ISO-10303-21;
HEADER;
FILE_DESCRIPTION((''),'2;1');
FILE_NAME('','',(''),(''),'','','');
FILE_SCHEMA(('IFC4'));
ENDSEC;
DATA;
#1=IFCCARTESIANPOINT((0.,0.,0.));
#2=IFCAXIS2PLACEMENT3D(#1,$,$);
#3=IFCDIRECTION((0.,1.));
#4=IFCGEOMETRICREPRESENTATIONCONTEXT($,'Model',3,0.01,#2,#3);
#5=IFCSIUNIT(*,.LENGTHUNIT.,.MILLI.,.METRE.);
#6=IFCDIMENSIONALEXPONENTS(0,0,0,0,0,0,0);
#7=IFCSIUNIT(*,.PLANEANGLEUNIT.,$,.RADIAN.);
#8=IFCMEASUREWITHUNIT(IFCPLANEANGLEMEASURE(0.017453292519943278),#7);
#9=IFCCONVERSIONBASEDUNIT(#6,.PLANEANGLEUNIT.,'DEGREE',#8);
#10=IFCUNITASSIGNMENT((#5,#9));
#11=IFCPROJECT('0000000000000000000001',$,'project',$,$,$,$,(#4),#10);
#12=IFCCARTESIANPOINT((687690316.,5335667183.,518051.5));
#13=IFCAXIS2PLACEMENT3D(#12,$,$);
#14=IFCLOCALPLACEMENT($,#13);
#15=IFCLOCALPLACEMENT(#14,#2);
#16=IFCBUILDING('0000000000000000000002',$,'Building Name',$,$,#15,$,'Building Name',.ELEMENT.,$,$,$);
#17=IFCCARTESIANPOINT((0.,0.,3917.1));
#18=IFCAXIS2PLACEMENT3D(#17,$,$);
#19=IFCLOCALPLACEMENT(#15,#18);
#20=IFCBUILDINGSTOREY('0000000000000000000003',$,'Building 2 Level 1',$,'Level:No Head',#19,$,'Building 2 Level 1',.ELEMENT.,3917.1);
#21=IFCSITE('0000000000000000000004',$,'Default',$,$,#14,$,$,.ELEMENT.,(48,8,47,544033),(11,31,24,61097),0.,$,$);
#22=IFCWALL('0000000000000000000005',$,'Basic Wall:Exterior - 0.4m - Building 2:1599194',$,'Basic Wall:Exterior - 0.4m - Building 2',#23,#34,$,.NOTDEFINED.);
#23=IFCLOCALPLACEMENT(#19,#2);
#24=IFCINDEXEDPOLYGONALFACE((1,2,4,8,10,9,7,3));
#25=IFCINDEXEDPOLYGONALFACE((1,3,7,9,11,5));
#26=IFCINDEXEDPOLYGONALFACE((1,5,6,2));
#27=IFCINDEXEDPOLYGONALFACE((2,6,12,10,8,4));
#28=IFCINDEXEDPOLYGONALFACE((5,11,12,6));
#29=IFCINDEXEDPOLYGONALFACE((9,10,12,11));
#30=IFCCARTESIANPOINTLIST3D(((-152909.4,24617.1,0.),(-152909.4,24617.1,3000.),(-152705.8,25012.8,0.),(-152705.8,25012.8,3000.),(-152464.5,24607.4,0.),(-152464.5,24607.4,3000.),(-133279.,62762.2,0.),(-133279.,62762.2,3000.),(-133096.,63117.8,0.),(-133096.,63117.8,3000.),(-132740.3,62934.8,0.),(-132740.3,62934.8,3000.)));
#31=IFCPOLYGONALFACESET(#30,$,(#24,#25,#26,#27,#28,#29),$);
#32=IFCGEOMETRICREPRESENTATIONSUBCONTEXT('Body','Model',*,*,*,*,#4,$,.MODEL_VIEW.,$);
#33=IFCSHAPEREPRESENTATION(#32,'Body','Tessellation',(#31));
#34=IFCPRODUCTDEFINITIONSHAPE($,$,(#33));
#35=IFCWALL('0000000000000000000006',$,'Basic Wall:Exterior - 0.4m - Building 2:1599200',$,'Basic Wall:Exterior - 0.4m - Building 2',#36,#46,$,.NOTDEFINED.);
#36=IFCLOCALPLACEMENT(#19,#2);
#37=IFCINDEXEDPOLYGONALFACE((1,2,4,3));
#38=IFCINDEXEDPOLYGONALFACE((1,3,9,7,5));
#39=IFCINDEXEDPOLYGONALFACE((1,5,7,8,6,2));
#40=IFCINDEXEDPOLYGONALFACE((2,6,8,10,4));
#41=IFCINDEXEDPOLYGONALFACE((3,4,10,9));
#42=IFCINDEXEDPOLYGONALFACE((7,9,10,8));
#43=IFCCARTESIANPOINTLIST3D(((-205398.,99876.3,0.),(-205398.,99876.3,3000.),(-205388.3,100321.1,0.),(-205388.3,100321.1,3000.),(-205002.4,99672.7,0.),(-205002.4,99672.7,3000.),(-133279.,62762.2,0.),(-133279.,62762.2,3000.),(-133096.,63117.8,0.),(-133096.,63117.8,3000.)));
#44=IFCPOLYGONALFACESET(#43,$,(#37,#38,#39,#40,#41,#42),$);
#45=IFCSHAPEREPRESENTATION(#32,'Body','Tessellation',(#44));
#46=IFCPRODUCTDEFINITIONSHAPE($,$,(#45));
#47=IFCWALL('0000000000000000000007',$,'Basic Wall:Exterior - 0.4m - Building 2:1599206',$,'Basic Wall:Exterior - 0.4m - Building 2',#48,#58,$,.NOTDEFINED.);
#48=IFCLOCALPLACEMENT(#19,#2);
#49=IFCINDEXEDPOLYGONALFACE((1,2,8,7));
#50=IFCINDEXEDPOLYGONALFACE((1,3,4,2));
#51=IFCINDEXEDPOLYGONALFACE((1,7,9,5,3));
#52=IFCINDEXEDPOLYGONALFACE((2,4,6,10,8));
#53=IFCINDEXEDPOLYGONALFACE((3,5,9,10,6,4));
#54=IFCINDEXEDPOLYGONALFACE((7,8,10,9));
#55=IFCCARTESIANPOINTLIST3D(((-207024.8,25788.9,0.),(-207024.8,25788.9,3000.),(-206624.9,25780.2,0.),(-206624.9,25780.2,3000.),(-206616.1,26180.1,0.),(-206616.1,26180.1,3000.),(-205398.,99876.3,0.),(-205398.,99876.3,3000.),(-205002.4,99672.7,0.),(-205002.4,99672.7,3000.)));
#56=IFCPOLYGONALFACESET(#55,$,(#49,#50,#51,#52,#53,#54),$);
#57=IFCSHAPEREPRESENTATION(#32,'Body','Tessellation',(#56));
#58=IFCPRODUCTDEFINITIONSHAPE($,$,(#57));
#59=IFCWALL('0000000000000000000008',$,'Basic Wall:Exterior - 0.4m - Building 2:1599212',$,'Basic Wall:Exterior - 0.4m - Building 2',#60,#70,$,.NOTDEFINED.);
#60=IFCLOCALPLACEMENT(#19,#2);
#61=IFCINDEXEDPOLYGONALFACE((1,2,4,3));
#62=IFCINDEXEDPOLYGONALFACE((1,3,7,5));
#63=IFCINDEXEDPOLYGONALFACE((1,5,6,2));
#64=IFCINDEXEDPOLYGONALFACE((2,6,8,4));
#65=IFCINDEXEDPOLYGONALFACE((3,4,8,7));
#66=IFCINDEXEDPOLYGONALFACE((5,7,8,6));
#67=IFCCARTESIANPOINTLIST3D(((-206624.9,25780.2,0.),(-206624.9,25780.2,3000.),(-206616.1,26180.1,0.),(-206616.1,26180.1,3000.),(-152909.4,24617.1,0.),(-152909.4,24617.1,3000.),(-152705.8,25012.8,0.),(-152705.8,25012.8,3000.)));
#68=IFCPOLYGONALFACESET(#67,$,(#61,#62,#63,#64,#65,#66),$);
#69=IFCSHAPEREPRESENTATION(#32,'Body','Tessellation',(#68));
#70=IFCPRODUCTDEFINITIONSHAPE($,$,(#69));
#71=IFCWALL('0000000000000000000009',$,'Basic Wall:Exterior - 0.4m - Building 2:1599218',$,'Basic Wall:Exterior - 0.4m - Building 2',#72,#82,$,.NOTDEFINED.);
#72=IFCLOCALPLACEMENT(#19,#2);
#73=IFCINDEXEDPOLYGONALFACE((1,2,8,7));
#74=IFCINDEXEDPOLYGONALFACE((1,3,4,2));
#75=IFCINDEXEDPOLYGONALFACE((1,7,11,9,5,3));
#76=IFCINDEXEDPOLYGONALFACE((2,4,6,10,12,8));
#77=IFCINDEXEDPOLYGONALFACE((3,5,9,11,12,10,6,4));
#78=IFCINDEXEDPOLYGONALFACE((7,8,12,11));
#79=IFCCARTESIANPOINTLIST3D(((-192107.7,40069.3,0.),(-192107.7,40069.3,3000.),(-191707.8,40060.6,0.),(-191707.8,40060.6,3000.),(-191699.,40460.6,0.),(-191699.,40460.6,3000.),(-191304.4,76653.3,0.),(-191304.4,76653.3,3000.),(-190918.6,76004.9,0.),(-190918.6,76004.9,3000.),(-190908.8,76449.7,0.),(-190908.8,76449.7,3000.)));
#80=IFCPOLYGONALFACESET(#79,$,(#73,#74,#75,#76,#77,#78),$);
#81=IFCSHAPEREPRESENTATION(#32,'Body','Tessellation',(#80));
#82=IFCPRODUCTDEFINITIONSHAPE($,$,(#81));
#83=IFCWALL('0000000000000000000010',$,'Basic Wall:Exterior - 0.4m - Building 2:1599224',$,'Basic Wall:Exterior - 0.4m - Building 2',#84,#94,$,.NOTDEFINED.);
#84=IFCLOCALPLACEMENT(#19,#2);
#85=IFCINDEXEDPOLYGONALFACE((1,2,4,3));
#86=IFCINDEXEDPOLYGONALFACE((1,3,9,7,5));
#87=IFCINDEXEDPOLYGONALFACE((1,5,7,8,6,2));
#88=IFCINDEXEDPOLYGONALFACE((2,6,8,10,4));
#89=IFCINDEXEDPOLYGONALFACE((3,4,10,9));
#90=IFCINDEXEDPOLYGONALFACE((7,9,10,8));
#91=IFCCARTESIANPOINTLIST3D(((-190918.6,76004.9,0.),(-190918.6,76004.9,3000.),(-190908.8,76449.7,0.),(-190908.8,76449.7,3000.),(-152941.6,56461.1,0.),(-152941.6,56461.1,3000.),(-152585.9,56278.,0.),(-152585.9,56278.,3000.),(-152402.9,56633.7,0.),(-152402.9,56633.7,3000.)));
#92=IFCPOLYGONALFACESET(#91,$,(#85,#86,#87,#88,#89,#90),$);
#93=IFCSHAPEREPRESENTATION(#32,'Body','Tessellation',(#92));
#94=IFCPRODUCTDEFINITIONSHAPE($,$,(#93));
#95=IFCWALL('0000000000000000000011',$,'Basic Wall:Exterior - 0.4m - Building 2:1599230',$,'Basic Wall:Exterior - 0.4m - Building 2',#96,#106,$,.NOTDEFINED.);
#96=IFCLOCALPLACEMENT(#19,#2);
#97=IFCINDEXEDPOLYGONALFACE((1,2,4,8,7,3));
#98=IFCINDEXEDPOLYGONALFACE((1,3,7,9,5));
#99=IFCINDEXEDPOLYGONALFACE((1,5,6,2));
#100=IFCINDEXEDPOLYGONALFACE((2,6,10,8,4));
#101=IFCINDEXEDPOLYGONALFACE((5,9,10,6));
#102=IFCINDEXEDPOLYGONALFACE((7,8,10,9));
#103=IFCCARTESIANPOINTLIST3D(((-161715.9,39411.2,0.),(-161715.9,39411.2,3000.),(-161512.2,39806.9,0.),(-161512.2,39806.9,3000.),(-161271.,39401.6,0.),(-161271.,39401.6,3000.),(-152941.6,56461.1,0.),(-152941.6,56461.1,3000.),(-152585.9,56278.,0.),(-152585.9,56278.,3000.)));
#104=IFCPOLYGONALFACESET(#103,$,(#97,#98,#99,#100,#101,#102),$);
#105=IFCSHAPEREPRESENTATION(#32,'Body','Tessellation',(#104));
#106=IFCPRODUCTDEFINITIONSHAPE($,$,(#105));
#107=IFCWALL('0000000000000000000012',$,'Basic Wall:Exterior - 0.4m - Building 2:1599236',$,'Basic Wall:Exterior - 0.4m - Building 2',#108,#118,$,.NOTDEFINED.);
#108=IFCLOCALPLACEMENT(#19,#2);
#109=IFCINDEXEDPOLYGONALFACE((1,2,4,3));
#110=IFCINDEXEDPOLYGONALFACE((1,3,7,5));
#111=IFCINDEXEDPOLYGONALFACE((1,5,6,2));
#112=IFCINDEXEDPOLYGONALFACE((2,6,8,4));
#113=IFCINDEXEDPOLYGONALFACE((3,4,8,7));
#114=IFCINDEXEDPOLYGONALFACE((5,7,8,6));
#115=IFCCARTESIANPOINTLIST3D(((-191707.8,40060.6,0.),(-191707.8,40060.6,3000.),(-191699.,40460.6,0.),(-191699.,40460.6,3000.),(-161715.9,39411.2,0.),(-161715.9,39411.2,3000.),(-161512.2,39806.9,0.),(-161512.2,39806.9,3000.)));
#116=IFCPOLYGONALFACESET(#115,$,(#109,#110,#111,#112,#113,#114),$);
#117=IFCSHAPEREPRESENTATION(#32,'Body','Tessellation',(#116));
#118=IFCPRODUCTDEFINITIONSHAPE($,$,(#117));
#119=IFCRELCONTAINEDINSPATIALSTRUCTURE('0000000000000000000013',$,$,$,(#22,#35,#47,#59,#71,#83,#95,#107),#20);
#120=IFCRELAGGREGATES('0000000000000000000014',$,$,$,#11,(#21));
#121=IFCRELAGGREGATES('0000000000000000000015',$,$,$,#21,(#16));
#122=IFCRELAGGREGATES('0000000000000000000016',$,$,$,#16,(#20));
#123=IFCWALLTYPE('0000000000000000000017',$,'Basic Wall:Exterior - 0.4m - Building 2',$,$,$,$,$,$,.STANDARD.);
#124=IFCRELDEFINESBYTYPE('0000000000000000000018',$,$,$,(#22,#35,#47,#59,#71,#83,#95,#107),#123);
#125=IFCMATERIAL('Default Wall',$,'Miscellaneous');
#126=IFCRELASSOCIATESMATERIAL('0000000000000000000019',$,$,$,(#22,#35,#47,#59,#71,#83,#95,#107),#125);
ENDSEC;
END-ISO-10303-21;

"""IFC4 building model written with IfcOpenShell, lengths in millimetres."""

from ifc_helpers import new_model, entity, si_unit, converted_unit, direction, frame, origin, place, context, subcontext, project, spatial, indexed_curve, outline, extrude, material, type_object, element, save


model = new_model("IFC4")

# Units and contexts
model_context = context("Model", 3, precision=0.01, world=origin(), true_north=direction((0.0, 1.0)))
body_context = subcontext(model_context, "Body", "Model", "MODEL_VIEW")
ifc_project = project(units=[si_unit("LENGTHUNIT", "METRE", prefix="MILLI"), converted_unit("PLANEANGLEUNIT", "DEGREE", entity("IfcPlaneAngleMeasure", 0.017453292519943278), si_unit("PLANEANGLEUNIT", "RADIAN"), dimensions=[0, 0, 0, 0, 0, 0, 0])], contexts=[model_context])

# Site, building, storey
site_placement = place(None, frame((687690316.0, 5335667183.0, 518051.5)))
site = spatial("IfcSite", under=ifc_project, at=site_placement, Name="Default", CompositionType="ELEMENT", RefLatitude=(48, 8, 47, 544033), RefLongitude=(11, 31, 24, 61097), RefElevation=0.0)
building_placement = place(site_placement, origin())
building = spatial("IfcBuilding", under=site, at=building_placement, Name="Building Name", LongName="Building Name", CompositionType="ELEMENT")
storey_placement = place(building_placement, frame((0.0, 0.0, 3917.1)))
storey = spatial("IfcBuildingStorey", under=building, at=storey_placement, Name="Building 2 Level 1", ObjectType="Level:No Head", LongName="Building 2 Level 1", CompositionType="ELEMENT", Elevation=3917.1)

# Walls
ifc_material_1 = material(Name="Default Wall", Category="Miscellaneous")
wall_type = type_object("IfcWallType", Name="Basic Wall:Exterior - 0.4m - Building 2", PredefinedType="STANDARD")
wall_1_placement = place(storey_placement, frame((-152731.6, 24525.6, 0.0), z_axis=(0.0, 0.0, 1.0), x_axis=(0.457585, 0.889166, 0.0)))
element("IfcWall", 1, at=wall_1_placement, inside=storey, type_object=wall_type, material=ifc_material_1, Name="Basic Wall:Exterior - 0.4m - Building 2:1599194", ObjectType="Basic Wall:Exterior - 0.4m - Building 2", PredefinedType="NOTDEFINED", context=body_context, shape_type="SweptSolid", body=[
    extrude(outline(indexed_curve([(43299.8, -200.0), (43299.8, 200.0), (42899.8, 200.0), (445.0, 200.0), (0.0, 200.0), (195.0, -200.0), (43299.8, -200.0)], self_intersect=False)), origin(), (0.0, 0.0, 1.0), 3000.0),
])
wall_2_placement = place(storey_placement, frame((-133187.5, 62940.0, 0.0), z_axis=(0.0, 0.0, 1.0), x_axis=(-0.889166, 0.457585, 0.0)))
element("IfcWall", 2, at=wall_2_placement, inside=storey, type_object=wall_type, material=ifc_material_1, Name="Basic Wall:Exterior - 0.4m - Building 2:1599200", ObjectType="Basic Wall:Exterior - 0.4m - Building 2", PredefinedType="NOTDEFINED", context=body_context, shape_type="SweptSolid", body=[
    extrude(outline(indexed_curve([(81303.5, -200.0), (81108.6, 200.0), (80663.7, 200.0), (0.0, 200.0), (0.0, -200.0), (81303.5, -200.0)], self_intersect=False)), origin(), (0.0, 0.0, 1.0), 3000.0),
])
wall_3_placement = place(storey_placement, frame((-205198.1, 99871.9, 0.0), z_axis=(0.0, 0.0, 1.0), x_axis=(-0.021952, -0.999759, 0.0)))
element("IfcWall", 3, at=wall_3_placement, inside=storey, type_object=wall_type, material=ifc_material_1, Name="Basic Wall:Exterior - 0.4m - Building 2:1599206", ObjectType="Basic Wall:Exterior - 0.4m - Building 2", PredefinedType="NOTDEFINED", context=body_context, shape_type="SweptSolid", body=[
    extrude(outline(indexed_curve([(74105.2, -200.0), (74105.1, 200.0), (73705.1, 200.0), (194.9, 200.0), (0.0, -200.0), (74105.2, -200.0)], self_intersect=False)), origin(), (0.0, 0.0, 1.0), 3000.0),
])
wall_4_placement = place(storey_placement, frame((-206620.6, 25980.2, 0.0), z_axis=(0.0, 0.0, 1.0), x_axis=(0.999766, -0.021649, 0.0)))
element("IfcWall", 4, at=wall_4_placement, inside=storey, type_object=wall_type, material=ifc_material_1, Name="Basic Wall:Exterior - 0.4m - Building 2:1599212", ObjectType="Basic Wall:Exterior - 0.4m - Building 2", PredefinedType="NOTDEFINED", context=body_context, shape_type="SweptSolid", body=[
    extrude(outline(indexed_curve([(53728.1, -200.0), (53923.1, 200.0), (0.1, 200.0), (0.0, -200.0), (53728.1, -200.0)], self_intersect=False)), origin(), (0.0, 0.0, 1.0), 3000.0),
])
wall_5_placement = place(storey_placement, frame((-191907.8, 40064.9, 0.0), z_axis=(0.0, 0.0, 1.0), x_axis=(0.021952, 0.999759, 0.0)))
element("IfcWall", 5, at=wall_5_placement, inside=storey, type_object=wall_type, material=ifc_material_1, Name="Basic Wall:Exterior - 0.4m - Building 2:1599218", ObjectType="Basic Wall:Exterior - 0.4m - Building 2", PredefinedType="NOTDEFINED", context=body_context, shape_type="SweptSolid", body=[
    extrude(outline(indexed_curve([(36398.0, -200.0), (36592.9, 200.0), (0.0, 200.0), (0.1, -200.0), (400.1, -200.0), (35953.1, -200.0), (36398.0, -200.0)], self_intersect=False)), origin(), (0.0, 0.0, 1.0), 3000.0),
])
wall_6_placement = place(storey_placement, frame((-191000.3, 76271.9, 0.0), z_axis=(0.0, 0.0, 1.0), x_axis=(0.889166, -0.457585, 0.0)))
element("IfcWall", 6, at=wall_6_placement, inside=storey, type_object=wall_type, material=ifc_material_1, Name="Basic Wall:Exterior - 0.4m - Building 2:1599224", ObjectType="Basic Wall:Exterior - 0.4m - Building 2", PredefinedType="NOTDEFINED", context=body_context, shape_type="SweptSolid", body=[
    extrude(outline(indexed_curve([(43305.7, -200.0), (43305.7, 200.0), (0.0, 200.0), (194.9, -200.0), (42905.7, -200.0), (43305.7, -200.0)], self_intersect=False)), origin(), (0.0, 0.0, 1.0), 3000.0),
])
wall_7_placement = place(storey_placement, frame((-152763.8, 56369.6, 0.0), z_axis=(0.0, 0.0, 1.0), x_axis=(-0.457585, -0.889166, 0.0)))
element("IfcWall", 7, at=wall_7_placement, inside=storey, type_object=wall_type, material=ifc_material_1, Name="Basic Wall:Exterior - 0.4m - Building 2:1599230", ObjectType="Basic Wall:Exterior - 0.4m - Building 2", PredefinedType="NOTDEFINED", context=body_context, shape_type="SweptSolid", body=[
    extrude(outline(indexed_curve([(19175.1, -200.0), (18980.1, 200.0), (0.0, 200.0), (0.0, -200.0), (18730.1, -200.0), (19175.1, -200.0)], self_intersect=False)), origin(), (0.0, 0.0, 1.0), 3000.0),
])
wall_8_placement = place(storey_placement, frame((-161516.6, 39606.9, 0.0), z_axis=(0.0, 0.0, 1.0), x_axis=(-0.999766, 0.021649, 0.0)))
element("IfcWall", 8, at=wall_8_placement, inside=storey, type_object=wall_type, material=ifc_material_1, Name="Basic Wall:Exterior - 0.4m - Building 2:1599236", ObjectType="Basic Wall:Exterior - 0.4m - Building 2", PredefinedType="NOTDEFINED", context=body_context, shape_type="SweptSolid", body=[
    extrude(outline(indexed_curve([(30193.9, -200.0), (30194.0, 200.0), (195.0, 200.0), (0.0, -200.0), (30193.9, -200.0)], self_intersect=False)), origin(), (0.0, 0.0, 1.0), 3000.0),
])

save(model, "model.ifc")
